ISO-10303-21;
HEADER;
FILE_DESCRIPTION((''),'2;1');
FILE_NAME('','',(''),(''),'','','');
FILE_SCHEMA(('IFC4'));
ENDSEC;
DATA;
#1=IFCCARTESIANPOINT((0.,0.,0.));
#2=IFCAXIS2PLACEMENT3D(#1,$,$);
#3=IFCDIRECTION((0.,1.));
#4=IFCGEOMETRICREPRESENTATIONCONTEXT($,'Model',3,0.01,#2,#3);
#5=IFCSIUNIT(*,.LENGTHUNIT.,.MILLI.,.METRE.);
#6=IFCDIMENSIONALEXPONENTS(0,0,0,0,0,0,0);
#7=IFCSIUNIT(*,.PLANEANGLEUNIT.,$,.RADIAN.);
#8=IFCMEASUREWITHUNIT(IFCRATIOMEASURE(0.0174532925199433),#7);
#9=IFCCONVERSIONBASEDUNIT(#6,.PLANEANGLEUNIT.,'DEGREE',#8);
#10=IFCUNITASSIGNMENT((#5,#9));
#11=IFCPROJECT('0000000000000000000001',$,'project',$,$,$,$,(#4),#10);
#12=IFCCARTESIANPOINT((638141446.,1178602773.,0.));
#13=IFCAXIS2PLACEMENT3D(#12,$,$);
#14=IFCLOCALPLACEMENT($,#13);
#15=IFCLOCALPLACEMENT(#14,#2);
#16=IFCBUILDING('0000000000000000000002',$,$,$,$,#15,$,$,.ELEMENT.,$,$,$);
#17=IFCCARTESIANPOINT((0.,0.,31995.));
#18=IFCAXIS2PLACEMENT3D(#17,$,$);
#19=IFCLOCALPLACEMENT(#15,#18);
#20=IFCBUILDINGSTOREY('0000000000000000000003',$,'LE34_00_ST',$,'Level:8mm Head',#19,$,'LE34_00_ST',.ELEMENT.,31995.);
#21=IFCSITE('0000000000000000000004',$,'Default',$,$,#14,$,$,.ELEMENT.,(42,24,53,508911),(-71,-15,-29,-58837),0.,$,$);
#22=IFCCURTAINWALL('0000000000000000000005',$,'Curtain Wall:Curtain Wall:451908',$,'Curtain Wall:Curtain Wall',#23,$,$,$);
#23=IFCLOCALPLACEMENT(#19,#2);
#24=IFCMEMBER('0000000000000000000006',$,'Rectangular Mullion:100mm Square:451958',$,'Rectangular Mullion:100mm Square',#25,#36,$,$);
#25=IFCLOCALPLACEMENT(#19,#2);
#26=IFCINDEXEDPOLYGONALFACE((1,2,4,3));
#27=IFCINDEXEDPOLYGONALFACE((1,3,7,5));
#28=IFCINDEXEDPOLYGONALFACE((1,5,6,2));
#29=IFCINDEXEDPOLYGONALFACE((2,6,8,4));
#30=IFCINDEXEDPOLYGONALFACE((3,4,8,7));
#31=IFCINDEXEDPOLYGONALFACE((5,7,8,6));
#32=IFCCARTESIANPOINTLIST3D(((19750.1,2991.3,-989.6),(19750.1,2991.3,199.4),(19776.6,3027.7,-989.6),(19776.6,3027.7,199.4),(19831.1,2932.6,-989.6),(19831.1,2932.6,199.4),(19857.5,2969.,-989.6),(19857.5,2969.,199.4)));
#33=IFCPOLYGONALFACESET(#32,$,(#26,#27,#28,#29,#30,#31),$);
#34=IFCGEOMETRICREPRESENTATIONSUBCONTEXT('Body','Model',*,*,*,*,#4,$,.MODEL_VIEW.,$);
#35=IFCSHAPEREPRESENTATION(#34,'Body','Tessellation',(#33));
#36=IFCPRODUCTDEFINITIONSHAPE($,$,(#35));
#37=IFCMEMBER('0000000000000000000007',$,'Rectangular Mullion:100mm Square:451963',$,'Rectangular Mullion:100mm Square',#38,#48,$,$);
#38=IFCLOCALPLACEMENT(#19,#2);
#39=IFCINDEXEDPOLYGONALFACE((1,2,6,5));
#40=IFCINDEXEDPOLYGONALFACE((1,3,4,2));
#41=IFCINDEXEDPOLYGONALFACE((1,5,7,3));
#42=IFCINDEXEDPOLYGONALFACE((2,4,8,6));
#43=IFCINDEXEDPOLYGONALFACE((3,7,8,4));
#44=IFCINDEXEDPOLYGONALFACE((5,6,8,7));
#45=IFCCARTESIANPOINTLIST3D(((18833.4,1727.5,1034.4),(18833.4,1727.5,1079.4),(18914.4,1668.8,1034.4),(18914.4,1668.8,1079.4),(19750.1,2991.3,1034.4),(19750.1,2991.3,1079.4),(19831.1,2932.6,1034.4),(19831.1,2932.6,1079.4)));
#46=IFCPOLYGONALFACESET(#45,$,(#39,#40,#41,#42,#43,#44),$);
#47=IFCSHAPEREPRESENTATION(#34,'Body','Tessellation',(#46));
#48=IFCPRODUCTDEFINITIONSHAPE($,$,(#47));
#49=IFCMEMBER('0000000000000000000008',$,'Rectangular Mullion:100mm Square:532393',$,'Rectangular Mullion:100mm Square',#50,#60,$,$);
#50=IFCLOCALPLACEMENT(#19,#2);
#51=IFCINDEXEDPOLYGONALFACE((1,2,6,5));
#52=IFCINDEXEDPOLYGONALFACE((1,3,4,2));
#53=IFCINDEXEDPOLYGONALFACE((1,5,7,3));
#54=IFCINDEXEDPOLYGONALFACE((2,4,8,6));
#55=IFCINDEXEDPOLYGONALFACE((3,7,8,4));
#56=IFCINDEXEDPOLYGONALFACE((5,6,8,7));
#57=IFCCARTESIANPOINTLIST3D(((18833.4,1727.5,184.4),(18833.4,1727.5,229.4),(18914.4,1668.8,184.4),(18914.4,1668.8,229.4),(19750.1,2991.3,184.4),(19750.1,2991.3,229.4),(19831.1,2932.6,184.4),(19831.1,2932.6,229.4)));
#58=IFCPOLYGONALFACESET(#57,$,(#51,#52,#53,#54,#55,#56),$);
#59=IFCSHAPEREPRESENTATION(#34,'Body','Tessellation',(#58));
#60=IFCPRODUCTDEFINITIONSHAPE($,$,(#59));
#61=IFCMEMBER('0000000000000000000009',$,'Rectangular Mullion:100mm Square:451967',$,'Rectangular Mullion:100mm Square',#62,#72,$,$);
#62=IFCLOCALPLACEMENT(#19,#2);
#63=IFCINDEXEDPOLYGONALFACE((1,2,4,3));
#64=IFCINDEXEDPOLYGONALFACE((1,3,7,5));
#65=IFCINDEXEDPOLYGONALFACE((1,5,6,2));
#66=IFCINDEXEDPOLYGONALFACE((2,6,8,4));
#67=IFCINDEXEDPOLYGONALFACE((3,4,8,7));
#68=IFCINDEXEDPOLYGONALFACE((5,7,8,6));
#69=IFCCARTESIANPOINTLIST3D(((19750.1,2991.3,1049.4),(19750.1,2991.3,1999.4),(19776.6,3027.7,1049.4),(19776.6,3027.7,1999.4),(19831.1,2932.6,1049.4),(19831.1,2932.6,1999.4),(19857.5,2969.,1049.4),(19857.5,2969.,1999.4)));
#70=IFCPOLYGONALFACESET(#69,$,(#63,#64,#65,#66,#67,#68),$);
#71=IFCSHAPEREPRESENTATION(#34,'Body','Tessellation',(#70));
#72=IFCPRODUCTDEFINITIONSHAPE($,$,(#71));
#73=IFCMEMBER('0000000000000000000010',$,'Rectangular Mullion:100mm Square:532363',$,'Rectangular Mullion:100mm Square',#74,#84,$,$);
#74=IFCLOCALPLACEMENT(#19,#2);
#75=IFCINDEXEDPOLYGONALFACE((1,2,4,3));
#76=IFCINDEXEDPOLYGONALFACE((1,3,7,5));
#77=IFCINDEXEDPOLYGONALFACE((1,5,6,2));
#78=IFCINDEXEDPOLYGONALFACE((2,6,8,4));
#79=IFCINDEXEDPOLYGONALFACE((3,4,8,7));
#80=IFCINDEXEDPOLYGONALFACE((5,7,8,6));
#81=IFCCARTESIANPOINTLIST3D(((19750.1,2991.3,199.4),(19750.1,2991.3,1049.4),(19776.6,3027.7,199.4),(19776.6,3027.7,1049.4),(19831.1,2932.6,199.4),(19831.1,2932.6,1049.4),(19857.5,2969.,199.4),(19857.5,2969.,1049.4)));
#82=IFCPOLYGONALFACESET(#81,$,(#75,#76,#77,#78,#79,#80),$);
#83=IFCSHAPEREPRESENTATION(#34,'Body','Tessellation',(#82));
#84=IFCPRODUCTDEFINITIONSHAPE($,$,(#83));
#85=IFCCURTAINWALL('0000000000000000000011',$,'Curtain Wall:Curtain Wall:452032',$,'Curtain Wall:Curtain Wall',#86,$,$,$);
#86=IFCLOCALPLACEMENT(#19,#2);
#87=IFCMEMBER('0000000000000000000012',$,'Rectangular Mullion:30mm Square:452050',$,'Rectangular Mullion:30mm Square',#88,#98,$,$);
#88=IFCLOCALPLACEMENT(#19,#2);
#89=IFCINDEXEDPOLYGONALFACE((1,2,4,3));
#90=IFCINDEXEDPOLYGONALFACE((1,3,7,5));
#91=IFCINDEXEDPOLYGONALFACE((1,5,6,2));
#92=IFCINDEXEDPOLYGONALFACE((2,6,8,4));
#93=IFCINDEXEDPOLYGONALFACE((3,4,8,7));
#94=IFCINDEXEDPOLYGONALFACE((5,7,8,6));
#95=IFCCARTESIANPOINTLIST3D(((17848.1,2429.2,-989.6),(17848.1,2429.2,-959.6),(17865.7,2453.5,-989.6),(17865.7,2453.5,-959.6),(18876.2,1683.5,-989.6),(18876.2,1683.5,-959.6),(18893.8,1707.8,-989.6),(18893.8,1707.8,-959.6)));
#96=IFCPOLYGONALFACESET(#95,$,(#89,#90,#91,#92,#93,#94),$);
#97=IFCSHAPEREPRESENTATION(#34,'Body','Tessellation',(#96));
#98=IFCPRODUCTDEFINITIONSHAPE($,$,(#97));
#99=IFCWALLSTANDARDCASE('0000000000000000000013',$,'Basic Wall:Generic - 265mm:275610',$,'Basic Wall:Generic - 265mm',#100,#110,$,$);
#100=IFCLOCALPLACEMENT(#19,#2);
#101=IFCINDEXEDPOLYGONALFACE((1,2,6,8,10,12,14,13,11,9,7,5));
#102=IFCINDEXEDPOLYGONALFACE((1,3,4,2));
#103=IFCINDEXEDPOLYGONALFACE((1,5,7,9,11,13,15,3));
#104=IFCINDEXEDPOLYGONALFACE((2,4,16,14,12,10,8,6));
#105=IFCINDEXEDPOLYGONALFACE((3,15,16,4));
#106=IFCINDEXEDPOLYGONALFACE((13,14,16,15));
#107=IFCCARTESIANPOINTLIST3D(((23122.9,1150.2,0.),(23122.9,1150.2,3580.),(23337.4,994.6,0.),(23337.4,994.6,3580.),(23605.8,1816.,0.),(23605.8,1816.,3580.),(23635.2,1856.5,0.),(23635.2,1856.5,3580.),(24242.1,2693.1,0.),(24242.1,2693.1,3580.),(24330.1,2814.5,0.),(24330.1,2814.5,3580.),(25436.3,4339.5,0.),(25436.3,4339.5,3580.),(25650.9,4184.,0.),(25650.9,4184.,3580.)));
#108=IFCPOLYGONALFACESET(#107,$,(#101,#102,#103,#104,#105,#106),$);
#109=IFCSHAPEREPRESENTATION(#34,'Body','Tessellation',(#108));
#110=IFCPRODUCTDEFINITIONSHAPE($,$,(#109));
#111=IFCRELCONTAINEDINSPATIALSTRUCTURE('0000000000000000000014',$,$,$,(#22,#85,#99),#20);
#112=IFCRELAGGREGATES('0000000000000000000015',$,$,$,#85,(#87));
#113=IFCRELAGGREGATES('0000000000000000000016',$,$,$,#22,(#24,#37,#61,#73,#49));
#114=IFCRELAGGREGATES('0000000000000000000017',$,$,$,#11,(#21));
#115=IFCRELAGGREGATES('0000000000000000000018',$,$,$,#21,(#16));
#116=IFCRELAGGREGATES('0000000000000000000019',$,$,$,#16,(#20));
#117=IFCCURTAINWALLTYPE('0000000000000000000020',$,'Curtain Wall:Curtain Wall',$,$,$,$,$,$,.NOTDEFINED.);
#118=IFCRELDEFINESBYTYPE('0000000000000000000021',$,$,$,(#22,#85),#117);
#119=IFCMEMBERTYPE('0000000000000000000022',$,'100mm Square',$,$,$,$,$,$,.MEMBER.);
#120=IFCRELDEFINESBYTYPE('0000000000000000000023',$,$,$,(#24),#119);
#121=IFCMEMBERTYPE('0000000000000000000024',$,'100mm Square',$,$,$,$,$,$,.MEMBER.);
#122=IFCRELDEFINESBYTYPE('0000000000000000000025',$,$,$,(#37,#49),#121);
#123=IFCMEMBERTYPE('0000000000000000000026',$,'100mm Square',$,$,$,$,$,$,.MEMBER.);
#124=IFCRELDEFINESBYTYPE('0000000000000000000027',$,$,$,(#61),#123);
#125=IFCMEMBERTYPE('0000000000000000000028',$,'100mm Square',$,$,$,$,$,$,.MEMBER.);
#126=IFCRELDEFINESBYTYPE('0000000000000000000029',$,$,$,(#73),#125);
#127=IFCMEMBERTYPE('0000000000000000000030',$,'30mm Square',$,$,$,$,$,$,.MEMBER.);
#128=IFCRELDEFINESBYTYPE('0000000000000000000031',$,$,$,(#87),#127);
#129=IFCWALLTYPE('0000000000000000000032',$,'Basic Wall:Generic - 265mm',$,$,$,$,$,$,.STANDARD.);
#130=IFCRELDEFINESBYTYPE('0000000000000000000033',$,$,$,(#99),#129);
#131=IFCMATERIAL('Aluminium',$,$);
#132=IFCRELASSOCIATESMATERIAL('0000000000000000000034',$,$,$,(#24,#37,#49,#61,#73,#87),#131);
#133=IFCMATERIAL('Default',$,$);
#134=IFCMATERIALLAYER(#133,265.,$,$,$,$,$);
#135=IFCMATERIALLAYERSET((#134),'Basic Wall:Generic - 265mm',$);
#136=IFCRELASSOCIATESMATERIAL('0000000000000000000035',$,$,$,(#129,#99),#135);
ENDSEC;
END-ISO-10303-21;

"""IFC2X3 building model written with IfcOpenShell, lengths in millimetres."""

from ifc_helpers import new_model, entity, si_unit, converted_unit, direction, frame, origin, origin_2d_with_axis, place, context, subcontext, project, spatial, polyline, rectangle, outline, extrude, source, transform, mapped, material, layer, layer_set, layer_usage, type_object, type_shapes, element, aggregate, save


model = new_model("IFC2X3")

# Units and contexts
model_context = context("Model", 3, precision=0.01, world=origin(), true_north=direction((0.0, 1.0)))
body_context = subcontext(model_context, "Body", "Model", "MODEL_VIEW")
ifc_project = project(units=[si_unit("LENGTHUNIT", "METRE", prefix="MILLI"), converted_unit("PLANEANGLEUNIT", "DEGREE", entity("IfcRatioMeasure", 0.0174532925199433), si_unit("PLANEANGLEUNIT", "RADIAN"), dimensions=[0, 0, 0, 0, 0, 0, 0])], contexts=[model_context])

# Site, building, storey
site_placement = place(None, frame((638141446.0, 1178602773.0, 0.0)))
site = spatial("IfcSite", under=ifc_project, at=site_placement, Name="Default", CompositionType="ELEMENT", RefLatitude=(42, 24, 53, 508911), RefLongitude=(-71, -15, -29, -58837), RefElevation=0.0)
building_placement = place(site_placement, origin())
building = spatial("IfcBuilding", under=site, at=building_placement, CompositionType="ELEMENT")
storey_placement = place(building_placement, frame((0.0, 0.0, 31995.0)))
storey = spatial("IfcBuildingStorey", under=building, at=storey_placement, Name="LE34_00_ST", ObjectType="Level:8mm Head", LongName="LE34_00_ST", CompositionType="ELEMENT", Elevation=31995.0)

# Curtain wall, members
curtain_wall_type = type_object("IfcCurtainWallType", Name="Curtain Wall:Curtain Wall", PredefinedType="NOTDEFINED")
curtain_wall_1_placement = place(storey_placement, frame((0.0, 0.0, -31995.0)))
curtain_wall_1 = element("IfcCurtainWall", 1, at=curtain_wall_1_placement, inside=storey, type_object=curtain_wall_type, Name="Curtain Wall:Curtain Wall:451908", ObjectType="Curtain Wall:Curtain Wall")
ifc_material_1 = material(Name="Aluminium")
member_type_1 = type_object("IfcMemberType", Name="100mm Square", PredefinedType="MEMBER")
shared_shape_1 = source(origin(), body_context, "Body", "SweptSolid", [
    extrude(rectangle(XDim=100.0, YDim=45.0, at=origin_2d_with_axis()), frame((-22.5, 0.0, -1189.0), z_axis=(0.0, 0.0, 1.0), x_axis=(0.0, -1.0, 0.0)), (0.0, 0.0, 1.0), 1189.0),
])
type_shapes(member_type_1, [shared_shape_1])
member_1_placement = place(storey_placement, frame((19817.0, 2998.4, -989.6), z_axis=(0.0, 0.0, -1.0), x_axis=(0.587164, 0.809468, 0.0)))
member_1 = element("IfcMember", 2, at=member_1_placement, type_object=member_type_1, material=ifc_material_1, Name="Rectangular Mullion:100mm Square:451958", ObjectType="Rectangular Mullion:100mm Square", context=body_context, shape_type="MappedRepresentation", body=[
    mapped(shared_shape_1, transform((0.0, 0.0, 0.0), scale=1.0)),
])
member_type_2 = type_object("IfcMemberType", Name="100mm Square", PredefinedType="MEMBER")
shared_shape_2 = source(origin(), body_context, "Body", "SweptSolid", [
    extrude(rectangle(XDim=100.0, YDim=45.0, at=origin_2d_with_axis()), frame((7.5, 0.0, -1561.3), z_axis=(0.0, 0.0, 1.0), x_axis=(0.0, -1.0, 0.0)), (0.0, 0.0, 1.0), 1561.3),
])
type_shapes(member_type_2, [shared_shape_2])
member_2_placement = place(storey_placement, frame((19790.6, 2962.0, 1049.4), z_axis=(0.587164, 0.809468, 0.0), x_axis=(0.0, 0.0, 1.0)))
member_2 = element("IfcMember", 3, at=member_2_placement, type_object=member_type_2, material=ifc_material_1, Name="Rectangular Mullion:100mm Square:451963", ObjectType="Rectangular Mullion:100mm Square", context=body_context, shape_type="MappedRepresentation", body=[
    mapped(shared_shape_2, transform((0.0, 0.0, 0.0), scale=1.0)),
])
member_3_placement = place(storey_placement, frame((19790.6, 2962.0, 199.4), z_axis=(0.587164, 0.809468, 0.0), x_axis=(0.0, 0.0, 1.0)))
member_3 = element("IfcMember", 4, at=member_3_placement, type_object=member_type_2, material=ifc_material_1, Name="Rectangular Mullion:100mm Square:532393", ObjectType="Rectangular Mullion:100mm Square", context=body_context, shape_type="MappedRepresentation", body=[
    mapped(shared_shape_2, transform((0.0, 0.0, 0.0), scale=1.0)),
])
member_type_3 = type_object("IfcMemberType", Name="100mm Square", PredefinedType="MEMBER")
shared_shape_3 = source(origin(), body_context, "Body", "SweptSolid", [
    extrude(rectangle(XDim=100.0, YDim=45.0, at=origin_2d_with_axis()), frame((-22.5, 0.0, -950.0), z_axis=(0.0, 0.0, 1.0), x_axis=(0.0, -1.0, 0.0)), (0.0, 0.0, 1.0), 950.0),
])
type_shapes(member_type_3, [shared_shape_3])
member_4_placement = place(storey_placement, frame((19817.0, 2998.4, 1049.4), z_axis=(0.0, 0.0, -1.0), x_axis=(0.587164, 0.809468, 0.0)))
member_4 = element("IfcMember", 5, at=member_4_placement, type_object=member_type_3, material=ifc_material_1, Name="Rectangular Mullion:100mm Square:451967", ObjectType="Rectangular Mullion:100mm Square", context=body_context, shape_type="MappedRepresentation", body=[
    mapped(shared_shape_3, transform((0.0, 0.0, 0.0), scale=1.0)),
])
member_type_4 = type_object("IfcMemberType", Name="100mm Square", PredefinedType="MEMBER")
shared_shape_4 = source(origin(), body_context, "Body", "SweptSolid", [
    extrude(rectangle(XDim=100.0, YDim=45.0, at=origin_2d_with_axis()), frame((-22.5, 0.0, -850.0), z_axis=(0.0, 0.0, 1.0), x_axis=(0.0, -1.0, 0.0)), (0.0, 0.0, 1.0), 850.0),
])
type_shapes(member_type_4, [shared_shape_4])
member_5_placement = place(storey_placement, frame((19817.0, 2998.4, 199.4), z_axis=(0.0, 0.0, -1.0), x_axis=(0.587164, 0.809468, 0.0)))
member_5 = element("IfcMember", 6, at=member_5_placement, type_object=member_type_4, material=ifc_material_1, Name="Rectangular Mullion:100mm Square:532363", ObjectType="Rectangular Mullion:100mm Square", context=body_context, shape_type="MappedRepresentation", body=[
    mapped(shared_shape_4, transform((0.0, 0.0, 0.0), scale=1.0)),
])

# Curtain wall, member
curtain_wall_2_placement = place(storey_placement, frame((0.0, 0.0, -31995.0)))
curtain_wall_2 = element("IfcCurtainWall", 7, at=curtain_wall_2_placement, inside=storey, type_object=curtain_wall_type, Name="Curtain Wall:Curtain Wall:452032", ObjectType="Curtain Wall:Curtain Wall")
member_type_5 = type_object("IfcMemberType", Name="30mm Square", PredefinedType="MEMBER")
shared_shape_5 = source(origin(), body_context, "Body", "SweptSolid", [
    extrude(rectangle(XDim=30.0, YDim=30.0, at=origin_2d_with_axis()), frame((-15.0, 0.0, -1270.0), z_axis=(0.0, 0.0, 1.0), x_axis=(0.0, -1.0, 0.0)), (0.0, 0.0, 1.0), 1270.0),
])
type_shapes(member_type_5, [shared_shape_5])
member_6_placement = place(storey_placement, frame((18885.0, 1695.7, -989.6), z_axis=(0.809468, -0.587164, 0.0), x_axis=(0.0, 0.0, -1.0)))
member_6 = element("IfcMember", 8, at=member_6_placement, type_object=member_type_5, material=ifc_material_1, Name="Rectangular Mullion:30mm Square:452050", ObjectType="Rectangular Mullion:30mm Square", context=body_context, shape_type="MappedRepresentation", body=[
    mapped(shared_shape_5, transform((0.0, 0.0, 0.0), scale=1.0)),
])
aggregate(curtain_wall_2, [member_6])

aggregate(curtain_wall_1, [member_1, member_2, member_4, member_5, member_3])

# Shared definitions
ifc_material_2 = material(Name="Default")

# Wall
ifc_layer_1 = layer(ifc_material_2, 265.0)
ifc_layer_set_1 = layer_set([ifc_layer_1], Name="Basic Wall:Generic - 265mm")
ifc_layer_usage_1 = layer_usage(ifc_layer_set_1, "AXIS2", "POSITIVE", -132.5)
wall_type_1 = type_object("IfcWallType", Name="Basic Wall:Generic - 265mm", PredefinedType="STANDARD", material=ifc_layer_set_1)
wall_1_placement = place(storey_placement, frame((23230.1, 1072.4, 0.0), z_axis=(0.0, 0.0, 1.0), x_axis=(0.587164, 0.809468, 0.0)))
element("IfcWallStandardCase", 9, at=wall_1_placement, inside=storey, type_object=wall_type_1, material=ifc_layer_usage_1, Name="Basic Wall:Generic - 265mm:275610", ObjectType="Basic Wall:Generic - 265mm", context=body_context, shape_type="SweptSolid", body=[
    extrude(outline(polyline([(3940.1, -132.5), (3940.0, 132.5), (2056.1, 132.5), (1906.1, 132.5), (872.5, 132.5), (822.5, 132.5), (0.0, 132.5), (0.0, -132.5), (3940.1, -132.5)])), origin(), (0.0, 0.0, 1.0), 3580.0),
])

save(model, "model.ifc")
